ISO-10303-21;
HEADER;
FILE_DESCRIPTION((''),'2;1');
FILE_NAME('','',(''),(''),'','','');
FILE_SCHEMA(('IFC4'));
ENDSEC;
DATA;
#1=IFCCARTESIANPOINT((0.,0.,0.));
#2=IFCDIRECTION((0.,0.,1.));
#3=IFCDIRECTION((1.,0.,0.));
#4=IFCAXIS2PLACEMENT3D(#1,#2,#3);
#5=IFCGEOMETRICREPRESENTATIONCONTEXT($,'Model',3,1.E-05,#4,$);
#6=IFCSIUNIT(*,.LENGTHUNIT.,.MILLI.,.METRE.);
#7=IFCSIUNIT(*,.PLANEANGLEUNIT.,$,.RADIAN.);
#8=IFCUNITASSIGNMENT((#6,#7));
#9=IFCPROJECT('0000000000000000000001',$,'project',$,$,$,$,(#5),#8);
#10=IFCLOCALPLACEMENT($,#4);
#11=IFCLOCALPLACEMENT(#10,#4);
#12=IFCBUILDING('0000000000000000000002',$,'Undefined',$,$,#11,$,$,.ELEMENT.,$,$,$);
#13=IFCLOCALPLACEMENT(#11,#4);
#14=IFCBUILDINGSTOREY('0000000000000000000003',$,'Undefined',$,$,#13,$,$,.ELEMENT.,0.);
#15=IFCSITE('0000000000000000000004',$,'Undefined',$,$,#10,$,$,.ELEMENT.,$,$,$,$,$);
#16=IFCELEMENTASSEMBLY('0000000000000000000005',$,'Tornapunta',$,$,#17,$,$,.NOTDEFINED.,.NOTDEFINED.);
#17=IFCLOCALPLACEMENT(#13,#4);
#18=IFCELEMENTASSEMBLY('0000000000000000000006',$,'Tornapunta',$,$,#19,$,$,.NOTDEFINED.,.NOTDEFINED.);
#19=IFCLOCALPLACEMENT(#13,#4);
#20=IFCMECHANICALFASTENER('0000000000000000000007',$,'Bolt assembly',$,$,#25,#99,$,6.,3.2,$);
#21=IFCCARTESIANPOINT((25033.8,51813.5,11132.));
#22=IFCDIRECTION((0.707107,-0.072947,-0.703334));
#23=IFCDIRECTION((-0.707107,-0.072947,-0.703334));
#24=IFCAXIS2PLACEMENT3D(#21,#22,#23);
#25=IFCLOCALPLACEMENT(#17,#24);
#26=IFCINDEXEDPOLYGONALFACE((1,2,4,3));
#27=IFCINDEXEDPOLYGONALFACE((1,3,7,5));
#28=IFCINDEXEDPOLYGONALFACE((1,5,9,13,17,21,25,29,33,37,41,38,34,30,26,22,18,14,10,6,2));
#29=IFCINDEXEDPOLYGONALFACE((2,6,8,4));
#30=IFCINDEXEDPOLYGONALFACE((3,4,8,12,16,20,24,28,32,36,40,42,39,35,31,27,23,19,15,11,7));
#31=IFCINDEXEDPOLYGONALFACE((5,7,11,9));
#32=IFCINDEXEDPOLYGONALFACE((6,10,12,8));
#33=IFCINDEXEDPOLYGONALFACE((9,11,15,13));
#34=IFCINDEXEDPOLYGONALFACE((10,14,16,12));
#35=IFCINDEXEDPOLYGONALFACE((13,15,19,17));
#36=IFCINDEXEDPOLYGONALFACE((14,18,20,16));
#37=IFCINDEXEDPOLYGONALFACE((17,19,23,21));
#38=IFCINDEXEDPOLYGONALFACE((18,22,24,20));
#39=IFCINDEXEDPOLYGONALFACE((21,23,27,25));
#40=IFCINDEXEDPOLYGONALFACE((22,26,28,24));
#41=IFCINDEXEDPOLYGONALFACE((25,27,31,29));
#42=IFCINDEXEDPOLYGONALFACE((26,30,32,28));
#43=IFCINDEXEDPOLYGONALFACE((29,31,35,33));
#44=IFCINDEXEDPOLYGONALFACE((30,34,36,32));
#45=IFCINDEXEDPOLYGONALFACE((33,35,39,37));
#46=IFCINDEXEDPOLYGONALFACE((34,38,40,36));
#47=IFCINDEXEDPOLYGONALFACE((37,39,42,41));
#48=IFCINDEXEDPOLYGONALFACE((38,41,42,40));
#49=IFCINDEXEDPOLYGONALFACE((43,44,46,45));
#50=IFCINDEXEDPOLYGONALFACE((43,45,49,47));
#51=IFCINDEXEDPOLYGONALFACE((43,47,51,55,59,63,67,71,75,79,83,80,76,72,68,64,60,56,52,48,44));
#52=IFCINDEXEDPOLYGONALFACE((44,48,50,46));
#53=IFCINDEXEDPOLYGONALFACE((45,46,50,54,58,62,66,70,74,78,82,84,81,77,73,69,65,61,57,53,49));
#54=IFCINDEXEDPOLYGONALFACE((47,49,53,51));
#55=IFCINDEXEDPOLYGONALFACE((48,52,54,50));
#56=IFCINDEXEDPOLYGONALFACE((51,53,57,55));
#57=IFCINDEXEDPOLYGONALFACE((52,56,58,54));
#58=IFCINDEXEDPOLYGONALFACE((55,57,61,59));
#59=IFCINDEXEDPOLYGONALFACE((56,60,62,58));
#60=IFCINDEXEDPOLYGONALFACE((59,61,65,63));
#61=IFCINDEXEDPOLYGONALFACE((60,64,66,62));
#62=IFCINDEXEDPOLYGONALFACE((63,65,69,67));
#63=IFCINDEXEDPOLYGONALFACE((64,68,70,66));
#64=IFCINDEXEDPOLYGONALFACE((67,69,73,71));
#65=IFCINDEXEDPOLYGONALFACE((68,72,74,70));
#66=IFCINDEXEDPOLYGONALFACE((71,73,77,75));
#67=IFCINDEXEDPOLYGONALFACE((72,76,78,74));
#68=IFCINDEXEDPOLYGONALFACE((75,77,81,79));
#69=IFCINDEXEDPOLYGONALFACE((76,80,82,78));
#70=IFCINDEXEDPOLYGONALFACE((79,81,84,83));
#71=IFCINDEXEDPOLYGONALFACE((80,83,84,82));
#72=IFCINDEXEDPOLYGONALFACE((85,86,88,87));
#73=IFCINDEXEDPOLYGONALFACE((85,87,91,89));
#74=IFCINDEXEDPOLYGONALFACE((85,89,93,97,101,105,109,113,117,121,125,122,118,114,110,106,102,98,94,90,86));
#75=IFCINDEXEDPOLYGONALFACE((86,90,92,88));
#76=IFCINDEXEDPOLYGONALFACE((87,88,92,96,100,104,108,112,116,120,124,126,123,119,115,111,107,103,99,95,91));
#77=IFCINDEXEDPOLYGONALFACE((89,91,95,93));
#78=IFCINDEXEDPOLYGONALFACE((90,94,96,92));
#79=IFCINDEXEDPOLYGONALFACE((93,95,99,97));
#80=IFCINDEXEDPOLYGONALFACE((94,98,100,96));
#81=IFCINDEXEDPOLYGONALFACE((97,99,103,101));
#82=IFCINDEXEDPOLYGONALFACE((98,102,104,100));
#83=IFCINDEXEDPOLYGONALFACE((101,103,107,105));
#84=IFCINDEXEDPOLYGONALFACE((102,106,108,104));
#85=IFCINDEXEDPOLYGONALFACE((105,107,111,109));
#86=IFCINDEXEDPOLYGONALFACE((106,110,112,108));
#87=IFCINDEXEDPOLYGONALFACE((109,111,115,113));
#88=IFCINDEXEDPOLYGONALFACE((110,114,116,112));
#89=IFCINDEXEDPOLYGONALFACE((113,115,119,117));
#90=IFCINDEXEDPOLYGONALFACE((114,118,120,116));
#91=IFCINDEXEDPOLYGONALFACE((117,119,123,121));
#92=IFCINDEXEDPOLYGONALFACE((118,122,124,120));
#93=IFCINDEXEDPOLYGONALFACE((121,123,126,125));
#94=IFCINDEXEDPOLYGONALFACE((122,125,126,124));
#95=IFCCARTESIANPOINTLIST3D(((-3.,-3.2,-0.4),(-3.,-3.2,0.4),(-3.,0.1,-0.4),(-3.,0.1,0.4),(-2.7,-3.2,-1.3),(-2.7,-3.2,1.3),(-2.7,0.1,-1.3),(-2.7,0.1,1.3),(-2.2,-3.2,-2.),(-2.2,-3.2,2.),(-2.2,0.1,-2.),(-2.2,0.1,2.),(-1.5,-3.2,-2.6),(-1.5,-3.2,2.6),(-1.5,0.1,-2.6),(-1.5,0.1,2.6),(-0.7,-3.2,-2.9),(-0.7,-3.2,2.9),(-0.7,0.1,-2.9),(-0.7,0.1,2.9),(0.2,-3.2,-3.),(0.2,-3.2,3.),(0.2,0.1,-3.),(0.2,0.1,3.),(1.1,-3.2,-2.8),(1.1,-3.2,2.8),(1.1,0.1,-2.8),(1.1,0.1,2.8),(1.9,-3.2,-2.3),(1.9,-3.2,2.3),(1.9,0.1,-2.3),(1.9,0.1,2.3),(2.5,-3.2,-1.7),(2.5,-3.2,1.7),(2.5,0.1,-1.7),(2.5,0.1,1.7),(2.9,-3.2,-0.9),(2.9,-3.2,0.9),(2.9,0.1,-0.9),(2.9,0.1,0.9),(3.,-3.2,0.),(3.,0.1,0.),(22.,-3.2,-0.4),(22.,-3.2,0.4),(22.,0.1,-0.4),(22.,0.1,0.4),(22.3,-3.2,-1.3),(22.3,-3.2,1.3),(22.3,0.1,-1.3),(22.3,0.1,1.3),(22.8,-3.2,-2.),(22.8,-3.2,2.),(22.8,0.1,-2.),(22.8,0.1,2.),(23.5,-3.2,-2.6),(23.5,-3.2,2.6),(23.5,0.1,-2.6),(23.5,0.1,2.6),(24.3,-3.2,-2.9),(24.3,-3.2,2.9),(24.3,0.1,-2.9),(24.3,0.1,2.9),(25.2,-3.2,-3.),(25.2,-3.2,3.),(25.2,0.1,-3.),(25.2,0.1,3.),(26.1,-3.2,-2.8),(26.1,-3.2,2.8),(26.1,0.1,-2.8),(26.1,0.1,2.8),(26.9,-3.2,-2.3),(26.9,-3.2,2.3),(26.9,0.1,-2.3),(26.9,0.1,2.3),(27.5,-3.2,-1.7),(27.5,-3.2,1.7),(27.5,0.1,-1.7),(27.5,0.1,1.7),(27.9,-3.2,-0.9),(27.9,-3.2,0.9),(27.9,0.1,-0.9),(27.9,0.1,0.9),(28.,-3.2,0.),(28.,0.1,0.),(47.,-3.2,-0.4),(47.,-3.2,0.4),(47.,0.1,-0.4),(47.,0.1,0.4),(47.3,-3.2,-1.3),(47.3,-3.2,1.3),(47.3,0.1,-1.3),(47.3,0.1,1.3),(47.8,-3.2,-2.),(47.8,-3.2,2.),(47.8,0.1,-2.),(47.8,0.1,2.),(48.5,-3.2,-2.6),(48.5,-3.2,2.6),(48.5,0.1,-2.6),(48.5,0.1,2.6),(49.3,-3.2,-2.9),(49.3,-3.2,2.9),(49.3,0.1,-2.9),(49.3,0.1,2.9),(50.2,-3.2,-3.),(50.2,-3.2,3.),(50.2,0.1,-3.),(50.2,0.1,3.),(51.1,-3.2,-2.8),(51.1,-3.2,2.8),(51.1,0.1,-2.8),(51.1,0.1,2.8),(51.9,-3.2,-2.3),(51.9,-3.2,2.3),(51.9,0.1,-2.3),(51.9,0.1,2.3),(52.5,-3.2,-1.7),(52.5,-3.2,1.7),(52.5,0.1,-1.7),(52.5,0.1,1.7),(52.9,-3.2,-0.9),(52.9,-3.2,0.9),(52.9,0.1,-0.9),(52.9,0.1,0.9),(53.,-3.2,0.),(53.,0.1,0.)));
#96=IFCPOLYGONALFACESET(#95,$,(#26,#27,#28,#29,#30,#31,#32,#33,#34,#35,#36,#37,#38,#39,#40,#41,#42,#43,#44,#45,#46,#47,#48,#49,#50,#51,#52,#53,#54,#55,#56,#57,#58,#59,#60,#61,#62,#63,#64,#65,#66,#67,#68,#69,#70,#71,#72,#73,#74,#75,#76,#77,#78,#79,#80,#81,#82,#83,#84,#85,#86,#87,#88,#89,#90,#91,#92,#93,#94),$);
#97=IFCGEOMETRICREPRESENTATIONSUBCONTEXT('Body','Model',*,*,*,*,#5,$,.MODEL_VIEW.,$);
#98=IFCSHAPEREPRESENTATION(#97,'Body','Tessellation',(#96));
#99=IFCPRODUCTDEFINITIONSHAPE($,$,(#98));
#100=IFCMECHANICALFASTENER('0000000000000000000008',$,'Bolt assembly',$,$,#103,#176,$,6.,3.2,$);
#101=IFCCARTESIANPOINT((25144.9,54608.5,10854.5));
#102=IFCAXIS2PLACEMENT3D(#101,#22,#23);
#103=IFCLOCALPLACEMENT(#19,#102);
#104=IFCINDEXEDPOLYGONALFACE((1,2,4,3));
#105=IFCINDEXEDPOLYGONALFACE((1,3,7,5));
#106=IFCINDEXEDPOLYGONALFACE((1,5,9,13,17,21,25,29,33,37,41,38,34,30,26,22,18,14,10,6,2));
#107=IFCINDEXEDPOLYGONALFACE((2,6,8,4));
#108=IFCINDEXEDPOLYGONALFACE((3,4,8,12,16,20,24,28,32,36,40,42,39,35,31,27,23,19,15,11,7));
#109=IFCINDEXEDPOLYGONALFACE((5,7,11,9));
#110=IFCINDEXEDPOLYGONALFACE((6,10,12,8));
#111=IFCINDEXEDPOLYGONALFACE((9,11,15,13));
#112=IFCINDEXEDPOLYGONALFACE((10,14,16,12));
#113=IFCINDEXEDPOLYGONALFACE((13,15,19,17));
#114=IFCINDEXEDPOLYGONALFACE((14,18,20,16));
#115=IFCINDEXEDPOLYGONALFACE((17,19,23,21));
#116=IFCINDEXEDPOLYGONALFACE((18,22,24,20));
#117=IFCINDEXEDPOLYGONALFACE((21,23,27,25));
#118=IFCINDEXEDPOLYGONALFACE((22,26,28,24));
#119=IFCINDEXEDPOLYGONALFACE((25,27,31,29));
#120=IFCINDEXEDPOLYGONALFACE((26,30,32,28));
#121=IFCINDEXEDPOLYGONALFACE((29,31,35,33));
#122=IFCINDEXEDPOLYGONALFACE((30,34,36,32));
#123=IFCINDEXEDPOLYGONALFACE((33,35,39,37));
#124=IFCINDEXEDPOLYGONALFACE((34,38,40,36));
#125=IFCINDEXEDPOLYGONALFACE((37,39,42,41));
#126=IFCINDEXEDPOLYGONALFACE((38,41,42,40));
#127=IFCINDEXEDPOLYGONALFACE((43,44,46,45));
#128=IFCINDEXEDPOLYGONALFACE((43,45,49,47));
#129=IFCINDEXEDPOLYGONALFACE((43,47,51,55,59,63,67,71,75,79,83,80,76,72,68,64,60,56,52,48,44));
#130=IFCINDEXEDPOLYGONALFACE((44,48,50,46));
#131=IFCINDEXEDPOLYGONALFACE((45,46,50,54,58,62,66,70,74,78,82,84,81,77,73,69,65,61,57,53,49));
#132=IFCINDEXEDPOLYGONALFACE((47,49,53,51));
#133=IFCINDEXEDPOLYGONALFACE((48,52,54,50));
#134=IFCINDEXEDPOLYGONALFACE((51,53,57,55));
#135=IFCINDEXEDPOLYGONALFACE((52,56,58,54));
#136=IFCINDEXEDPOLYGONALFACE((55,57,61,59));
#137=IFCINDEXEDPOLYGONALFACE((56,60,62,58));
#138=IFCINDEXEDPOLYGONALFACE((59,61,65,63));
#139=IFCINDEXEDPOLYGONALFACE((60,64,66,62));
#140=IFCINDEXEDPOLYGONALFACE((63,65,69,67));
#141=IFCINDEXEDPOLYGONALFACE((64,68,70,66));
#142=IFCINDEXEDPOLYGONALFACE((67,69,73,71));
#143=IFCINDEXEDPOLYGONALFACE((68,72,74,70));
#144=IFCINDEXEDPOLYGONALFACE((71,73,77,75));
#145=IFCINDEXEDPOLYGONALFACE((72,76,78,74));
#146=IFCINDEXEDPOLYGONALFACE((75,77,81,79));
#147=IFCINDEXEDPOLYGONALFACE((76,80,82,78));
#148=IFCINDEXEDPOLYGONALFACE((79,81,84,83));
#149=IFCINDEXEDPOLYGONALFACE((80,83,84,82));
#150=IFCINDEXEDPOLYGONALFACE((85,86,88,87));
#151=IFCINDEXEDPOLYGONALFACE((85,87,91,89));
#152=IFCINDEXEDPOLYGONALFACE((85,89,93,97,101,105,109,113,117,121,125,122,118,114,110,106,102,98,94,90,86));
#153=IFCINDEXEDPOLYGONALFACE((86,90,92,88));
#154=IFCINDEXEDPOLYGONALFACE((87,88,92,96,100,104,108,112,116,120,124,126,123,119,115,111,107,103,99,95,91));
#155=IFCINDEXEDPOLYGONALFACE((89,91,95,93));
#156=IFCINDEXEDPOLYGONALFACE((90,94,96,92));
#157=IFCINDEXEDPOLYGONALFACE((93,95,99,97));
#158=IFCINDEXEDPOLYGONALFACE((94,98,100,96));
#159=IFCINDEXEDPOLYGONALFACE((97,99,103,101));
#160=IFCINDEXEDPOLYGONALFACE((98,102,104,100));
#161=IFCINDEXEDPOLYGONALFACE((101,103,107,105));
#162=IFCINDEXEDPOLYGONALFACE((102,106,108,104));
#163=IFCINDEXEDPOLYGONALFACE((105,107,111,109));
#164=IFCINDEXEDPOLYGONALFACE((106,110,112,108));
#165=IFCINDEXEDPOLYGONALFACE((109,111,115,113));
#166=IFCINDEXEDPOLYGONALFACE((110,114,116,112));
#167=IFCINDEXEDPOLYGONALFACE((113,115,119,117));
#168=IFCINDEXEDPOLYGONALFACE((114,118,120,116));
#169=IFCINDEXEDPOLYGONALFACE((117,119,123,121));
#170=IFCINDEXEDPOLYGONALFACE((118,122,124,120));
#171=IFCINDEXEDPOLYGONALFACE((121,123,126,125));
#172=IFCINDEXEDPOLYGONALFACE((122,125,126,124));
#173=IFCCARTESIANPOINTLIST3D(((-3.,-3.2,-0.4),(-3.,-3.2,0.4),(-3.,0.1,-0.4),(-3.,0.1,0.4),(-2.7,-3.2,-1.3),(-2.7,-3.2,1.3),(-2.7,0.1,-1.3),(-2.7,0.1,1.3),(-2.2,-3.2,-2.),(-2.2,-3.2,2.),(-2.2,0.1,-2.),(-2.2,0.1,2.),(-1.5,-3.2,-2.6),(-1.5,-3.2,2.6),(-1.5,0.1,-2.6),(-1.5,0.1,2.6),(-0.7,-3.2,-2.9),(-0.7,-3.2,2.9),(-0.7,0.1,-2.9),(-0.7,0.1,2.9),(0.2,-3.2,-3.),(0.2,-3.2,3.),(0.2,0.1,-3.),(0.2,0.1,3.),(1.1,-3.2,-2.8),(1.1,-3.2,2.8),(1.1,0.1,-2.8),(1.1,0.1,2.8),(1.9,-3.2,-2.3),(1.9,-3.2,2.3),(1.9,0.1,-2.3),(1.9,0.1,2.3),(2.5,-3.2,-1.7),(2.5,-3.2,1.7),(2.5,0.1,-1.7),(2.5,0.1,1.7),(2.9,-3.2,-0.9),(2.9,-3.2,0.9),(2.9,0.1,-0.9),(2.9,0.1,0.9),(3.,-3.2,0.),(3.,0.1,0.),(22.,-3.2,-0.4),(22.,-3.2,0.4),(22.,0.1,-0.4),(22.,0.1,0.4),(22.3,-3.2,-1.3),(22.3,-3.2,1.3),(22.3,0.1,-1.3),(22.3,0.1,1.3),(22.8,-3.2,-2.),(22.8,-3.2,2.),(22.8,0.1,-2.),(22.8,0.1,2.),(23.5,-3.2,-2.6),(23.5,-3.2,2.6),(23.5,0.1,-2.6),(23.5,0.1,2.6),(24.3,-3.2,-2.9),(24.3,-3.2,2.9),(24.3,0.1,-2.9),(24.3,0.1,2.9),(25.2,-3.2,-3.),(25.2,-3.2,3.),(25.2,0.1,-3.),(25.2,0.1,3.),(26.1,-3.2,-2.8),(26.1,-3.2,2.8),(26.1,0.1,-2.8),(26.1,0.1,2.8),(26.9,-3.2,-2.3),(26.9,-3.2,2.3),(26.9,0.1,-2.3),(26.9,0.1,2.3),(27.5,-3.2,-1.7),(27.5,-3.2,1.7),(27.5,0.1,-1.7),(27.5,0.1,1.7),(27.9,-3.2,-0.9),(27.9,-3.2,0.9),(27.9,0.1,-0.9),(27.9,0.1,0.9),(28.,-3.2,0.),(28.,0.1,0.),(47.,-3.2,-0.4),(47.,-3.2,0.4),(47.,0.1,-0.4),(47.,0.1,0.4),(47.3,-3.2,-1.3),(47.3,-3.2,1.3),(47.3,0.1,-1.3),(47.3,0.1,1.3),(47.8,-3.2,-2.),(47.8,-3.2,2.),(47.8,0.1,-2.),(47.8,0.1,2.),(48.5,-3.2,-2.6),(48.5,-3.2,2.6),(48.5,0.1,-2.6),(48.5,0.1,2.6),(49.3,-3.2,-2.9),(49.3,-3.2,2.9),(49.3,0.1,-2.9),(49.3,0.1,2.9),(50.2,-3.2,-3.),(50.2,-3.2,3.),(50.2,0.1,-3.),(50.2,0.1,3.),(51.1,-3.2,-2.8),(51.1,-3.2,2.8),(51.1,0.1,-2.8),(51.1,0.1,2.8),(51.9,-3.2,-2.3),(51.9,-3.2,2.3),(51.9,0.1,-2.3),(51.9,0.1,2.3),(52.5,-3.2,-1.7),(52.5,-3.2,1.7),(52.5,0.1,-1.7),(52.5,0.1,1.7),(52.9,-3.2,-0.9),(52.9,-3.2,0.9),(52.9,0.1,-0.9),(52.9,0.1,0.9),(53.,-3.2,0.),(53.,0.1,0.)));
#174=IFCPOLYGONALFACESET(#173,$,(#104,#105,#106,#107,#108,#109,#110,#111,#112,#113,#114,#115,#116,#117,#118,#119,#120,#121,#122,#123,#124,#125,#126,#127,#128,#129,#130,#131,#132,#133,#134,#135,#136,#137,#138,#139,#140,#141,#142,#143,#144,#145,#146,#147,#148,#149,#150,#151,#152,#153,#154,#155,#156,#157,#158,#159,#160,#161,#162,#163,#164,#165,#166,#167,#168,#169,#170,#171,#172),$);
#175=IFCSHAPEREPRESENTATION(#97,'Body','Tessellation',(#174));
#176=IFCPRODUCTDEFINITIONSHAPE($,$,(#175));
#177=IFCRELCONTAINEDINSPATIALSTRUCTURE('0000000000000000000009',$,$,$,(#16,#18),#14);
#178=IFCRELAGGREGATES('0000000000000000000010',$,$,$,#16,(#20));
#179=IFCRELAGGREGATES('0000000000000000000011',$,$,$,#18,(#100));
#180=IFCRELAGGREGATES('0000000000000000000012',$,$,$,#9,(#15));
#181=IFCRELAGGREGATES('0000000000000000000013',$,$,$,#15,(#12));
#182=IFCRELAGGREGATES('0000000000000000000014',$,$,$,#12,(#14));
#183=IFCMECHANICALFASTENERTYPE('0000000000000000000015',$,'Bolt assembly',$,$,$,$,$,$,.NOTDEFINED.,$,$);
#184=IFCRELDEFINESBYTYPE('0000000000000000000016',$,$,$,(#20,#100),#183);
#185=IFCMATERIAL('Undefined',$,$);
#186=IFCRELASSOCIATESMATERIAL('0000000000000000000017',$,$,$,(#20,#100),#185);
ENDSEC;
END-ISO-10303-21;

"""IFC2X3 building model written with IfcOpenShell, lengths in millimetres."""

from ifc_helpers import new_model, si_unit, frame, origin_with_axes, origin_2d_with_axis, place, context, subcontext, project, spatial, circle, extrude, source, transform, mapped, material, type_object, element, aggregate, save


model = new_model("IFC2X3")

# Units and contexts
model_context = context("Model", 3, precision=1e-05, world=origin_with_axes())
body_context = subcontext(model_context, "Body", "Model", "MODEL_VIEW")
ifc_project = project(units=[si_unit("LENGTHUNIT", "METRE", prefix="MILLI"), si_unit("PLANEANGLEUNIT", "RADIAN")], contexts=[model_context])

# Site, building, storey
site_placement = place(None, origin_with_axes())
site = spatial("IfcSite", under=ifc_project, at=site_placement, Name="Undefined", CompositionType="ELEMENT")
building_placement = place(site_placement, origin_with_axes())
building = spatial("IfcBuilding", under=site, at=building_placement, Name="Undefined", CompositionType="ELEMENT")
storey_placement = place(building_placement, origin_with_axes())
storey = spatial("IfcBuildingStorey", under=building, at=storey_placement, Name="Undefined", CompositionType="ELEMENT", Elevation=0.0)

# Element assemblies
assembly_1_placement = place(storey_placement, origin_with_axes())
assembly_1 = element("IfcElementAssembly", 1, at=assembly_1_placement, inside=storey, Name="Tornapunta", AssemblyPlace="NOTDEFINED", PredefinedType="NOTDEFINED")
assembly_2_placement = place(storey_placement, origin_with_axes())
assembly_2 = element("IfcElementAssembly", 2, at=assembly_2_placement, inside=storey, Name="Tornapunta", AssemblyPlace="NOTDEFINED", PredefinedType="NOTDEFINED")

# Shared definitions
ifc_material_1 = material(Name="Undefined")
mechanical_fastener_type = type_object("IfcMechanicalFastenerType", Name="Bolt assembly")

# Shared definitions
shared_shape_1 = source(origin_with_axes(), body_context, "Body", "SweptSolid", [
    extrude(circle(Radius=3.0, at=origin_2d_with_axis()), frame((0.0, -3.2, 0.0), z_axis=(0.0, 1.0, 0.0), x_axis=(1.0, 0.0, 0.0)), (0.0, 0.0, 1.0), 3.3),
])

# Mechanical fasteners
mechanical_fastener_1_placement = place(assembly_1_placement, frame((25033.8, 51813.5, 11132.0), z_axis=(0.707107, -0.072947, -0.703334), x_axis=(-0.707107, -0.072947, -0.703334)))
mechanical_fastener_1 = element("IfcMechanicalFastener", 3, at=mechanical_fastener_1_placement, type_object=mechanical_fastener_type, material=ifc_material_1, Name="Bolt assembly", NominalDiameter=6.0, NominalLength=3.2, context=body_context, shape_type="MappedRepresentation", body=[
    mapped(shared_shape_1, transform((0.0, 0.0, 0.0))),
    mapped(shared_shape_1, transform((25.0, 0.0, 0.0))),
    mapped(shared_shape_1, transform((50.0, 0.0, 0.0))),
])
aggregate(assembly_1, [mechanical_fastener_1])
shared_shape_2 = source(origin_with_axes(), body_context, "Body", "SweptSolid", [
    extrude(circle(Radius=3.0, at=origin_2d_with_axis()), frame((0.0, -3.2, 0.0), z_axis=(0.0, 1.0, 0.0), x_axis=(1.0, 0.0, 0.0)), (0.0, 0.0, 1.0), 3.3),
])
mechanical_fastener_2_placement = place(assembly_2_placement, frame((25144.9, 54608.5, 10854.5), z_axis=(0.707107, -0.072947, -0.703334), x_axis=(-0.707107, -0.072947, -0.703334)))
mechanical_fastener_2 = element("IfcMechanicalFastener", 4, at=mechanical_fastener_2_placement, type_object=mechanical_fastener_type, material=ifc_material_1, Name="Bolt assembly", NominalDiameter=6.0, NominalLength=3.2, context=body_context, shape_type="MappedRepresentation", body=[
    mapped(shared_shape_2, transform((0.0, 0.0, 0.0))),
    mapped(shared_shape_2, transform((25.0, 0.0, 0.0))),
    mapped(shared_shape_2, transform((50.0, 0.0, 0.0))),
])
aggregate(assembly_2, [mechanical_fastener_2])

save(model, "model.ifc")
